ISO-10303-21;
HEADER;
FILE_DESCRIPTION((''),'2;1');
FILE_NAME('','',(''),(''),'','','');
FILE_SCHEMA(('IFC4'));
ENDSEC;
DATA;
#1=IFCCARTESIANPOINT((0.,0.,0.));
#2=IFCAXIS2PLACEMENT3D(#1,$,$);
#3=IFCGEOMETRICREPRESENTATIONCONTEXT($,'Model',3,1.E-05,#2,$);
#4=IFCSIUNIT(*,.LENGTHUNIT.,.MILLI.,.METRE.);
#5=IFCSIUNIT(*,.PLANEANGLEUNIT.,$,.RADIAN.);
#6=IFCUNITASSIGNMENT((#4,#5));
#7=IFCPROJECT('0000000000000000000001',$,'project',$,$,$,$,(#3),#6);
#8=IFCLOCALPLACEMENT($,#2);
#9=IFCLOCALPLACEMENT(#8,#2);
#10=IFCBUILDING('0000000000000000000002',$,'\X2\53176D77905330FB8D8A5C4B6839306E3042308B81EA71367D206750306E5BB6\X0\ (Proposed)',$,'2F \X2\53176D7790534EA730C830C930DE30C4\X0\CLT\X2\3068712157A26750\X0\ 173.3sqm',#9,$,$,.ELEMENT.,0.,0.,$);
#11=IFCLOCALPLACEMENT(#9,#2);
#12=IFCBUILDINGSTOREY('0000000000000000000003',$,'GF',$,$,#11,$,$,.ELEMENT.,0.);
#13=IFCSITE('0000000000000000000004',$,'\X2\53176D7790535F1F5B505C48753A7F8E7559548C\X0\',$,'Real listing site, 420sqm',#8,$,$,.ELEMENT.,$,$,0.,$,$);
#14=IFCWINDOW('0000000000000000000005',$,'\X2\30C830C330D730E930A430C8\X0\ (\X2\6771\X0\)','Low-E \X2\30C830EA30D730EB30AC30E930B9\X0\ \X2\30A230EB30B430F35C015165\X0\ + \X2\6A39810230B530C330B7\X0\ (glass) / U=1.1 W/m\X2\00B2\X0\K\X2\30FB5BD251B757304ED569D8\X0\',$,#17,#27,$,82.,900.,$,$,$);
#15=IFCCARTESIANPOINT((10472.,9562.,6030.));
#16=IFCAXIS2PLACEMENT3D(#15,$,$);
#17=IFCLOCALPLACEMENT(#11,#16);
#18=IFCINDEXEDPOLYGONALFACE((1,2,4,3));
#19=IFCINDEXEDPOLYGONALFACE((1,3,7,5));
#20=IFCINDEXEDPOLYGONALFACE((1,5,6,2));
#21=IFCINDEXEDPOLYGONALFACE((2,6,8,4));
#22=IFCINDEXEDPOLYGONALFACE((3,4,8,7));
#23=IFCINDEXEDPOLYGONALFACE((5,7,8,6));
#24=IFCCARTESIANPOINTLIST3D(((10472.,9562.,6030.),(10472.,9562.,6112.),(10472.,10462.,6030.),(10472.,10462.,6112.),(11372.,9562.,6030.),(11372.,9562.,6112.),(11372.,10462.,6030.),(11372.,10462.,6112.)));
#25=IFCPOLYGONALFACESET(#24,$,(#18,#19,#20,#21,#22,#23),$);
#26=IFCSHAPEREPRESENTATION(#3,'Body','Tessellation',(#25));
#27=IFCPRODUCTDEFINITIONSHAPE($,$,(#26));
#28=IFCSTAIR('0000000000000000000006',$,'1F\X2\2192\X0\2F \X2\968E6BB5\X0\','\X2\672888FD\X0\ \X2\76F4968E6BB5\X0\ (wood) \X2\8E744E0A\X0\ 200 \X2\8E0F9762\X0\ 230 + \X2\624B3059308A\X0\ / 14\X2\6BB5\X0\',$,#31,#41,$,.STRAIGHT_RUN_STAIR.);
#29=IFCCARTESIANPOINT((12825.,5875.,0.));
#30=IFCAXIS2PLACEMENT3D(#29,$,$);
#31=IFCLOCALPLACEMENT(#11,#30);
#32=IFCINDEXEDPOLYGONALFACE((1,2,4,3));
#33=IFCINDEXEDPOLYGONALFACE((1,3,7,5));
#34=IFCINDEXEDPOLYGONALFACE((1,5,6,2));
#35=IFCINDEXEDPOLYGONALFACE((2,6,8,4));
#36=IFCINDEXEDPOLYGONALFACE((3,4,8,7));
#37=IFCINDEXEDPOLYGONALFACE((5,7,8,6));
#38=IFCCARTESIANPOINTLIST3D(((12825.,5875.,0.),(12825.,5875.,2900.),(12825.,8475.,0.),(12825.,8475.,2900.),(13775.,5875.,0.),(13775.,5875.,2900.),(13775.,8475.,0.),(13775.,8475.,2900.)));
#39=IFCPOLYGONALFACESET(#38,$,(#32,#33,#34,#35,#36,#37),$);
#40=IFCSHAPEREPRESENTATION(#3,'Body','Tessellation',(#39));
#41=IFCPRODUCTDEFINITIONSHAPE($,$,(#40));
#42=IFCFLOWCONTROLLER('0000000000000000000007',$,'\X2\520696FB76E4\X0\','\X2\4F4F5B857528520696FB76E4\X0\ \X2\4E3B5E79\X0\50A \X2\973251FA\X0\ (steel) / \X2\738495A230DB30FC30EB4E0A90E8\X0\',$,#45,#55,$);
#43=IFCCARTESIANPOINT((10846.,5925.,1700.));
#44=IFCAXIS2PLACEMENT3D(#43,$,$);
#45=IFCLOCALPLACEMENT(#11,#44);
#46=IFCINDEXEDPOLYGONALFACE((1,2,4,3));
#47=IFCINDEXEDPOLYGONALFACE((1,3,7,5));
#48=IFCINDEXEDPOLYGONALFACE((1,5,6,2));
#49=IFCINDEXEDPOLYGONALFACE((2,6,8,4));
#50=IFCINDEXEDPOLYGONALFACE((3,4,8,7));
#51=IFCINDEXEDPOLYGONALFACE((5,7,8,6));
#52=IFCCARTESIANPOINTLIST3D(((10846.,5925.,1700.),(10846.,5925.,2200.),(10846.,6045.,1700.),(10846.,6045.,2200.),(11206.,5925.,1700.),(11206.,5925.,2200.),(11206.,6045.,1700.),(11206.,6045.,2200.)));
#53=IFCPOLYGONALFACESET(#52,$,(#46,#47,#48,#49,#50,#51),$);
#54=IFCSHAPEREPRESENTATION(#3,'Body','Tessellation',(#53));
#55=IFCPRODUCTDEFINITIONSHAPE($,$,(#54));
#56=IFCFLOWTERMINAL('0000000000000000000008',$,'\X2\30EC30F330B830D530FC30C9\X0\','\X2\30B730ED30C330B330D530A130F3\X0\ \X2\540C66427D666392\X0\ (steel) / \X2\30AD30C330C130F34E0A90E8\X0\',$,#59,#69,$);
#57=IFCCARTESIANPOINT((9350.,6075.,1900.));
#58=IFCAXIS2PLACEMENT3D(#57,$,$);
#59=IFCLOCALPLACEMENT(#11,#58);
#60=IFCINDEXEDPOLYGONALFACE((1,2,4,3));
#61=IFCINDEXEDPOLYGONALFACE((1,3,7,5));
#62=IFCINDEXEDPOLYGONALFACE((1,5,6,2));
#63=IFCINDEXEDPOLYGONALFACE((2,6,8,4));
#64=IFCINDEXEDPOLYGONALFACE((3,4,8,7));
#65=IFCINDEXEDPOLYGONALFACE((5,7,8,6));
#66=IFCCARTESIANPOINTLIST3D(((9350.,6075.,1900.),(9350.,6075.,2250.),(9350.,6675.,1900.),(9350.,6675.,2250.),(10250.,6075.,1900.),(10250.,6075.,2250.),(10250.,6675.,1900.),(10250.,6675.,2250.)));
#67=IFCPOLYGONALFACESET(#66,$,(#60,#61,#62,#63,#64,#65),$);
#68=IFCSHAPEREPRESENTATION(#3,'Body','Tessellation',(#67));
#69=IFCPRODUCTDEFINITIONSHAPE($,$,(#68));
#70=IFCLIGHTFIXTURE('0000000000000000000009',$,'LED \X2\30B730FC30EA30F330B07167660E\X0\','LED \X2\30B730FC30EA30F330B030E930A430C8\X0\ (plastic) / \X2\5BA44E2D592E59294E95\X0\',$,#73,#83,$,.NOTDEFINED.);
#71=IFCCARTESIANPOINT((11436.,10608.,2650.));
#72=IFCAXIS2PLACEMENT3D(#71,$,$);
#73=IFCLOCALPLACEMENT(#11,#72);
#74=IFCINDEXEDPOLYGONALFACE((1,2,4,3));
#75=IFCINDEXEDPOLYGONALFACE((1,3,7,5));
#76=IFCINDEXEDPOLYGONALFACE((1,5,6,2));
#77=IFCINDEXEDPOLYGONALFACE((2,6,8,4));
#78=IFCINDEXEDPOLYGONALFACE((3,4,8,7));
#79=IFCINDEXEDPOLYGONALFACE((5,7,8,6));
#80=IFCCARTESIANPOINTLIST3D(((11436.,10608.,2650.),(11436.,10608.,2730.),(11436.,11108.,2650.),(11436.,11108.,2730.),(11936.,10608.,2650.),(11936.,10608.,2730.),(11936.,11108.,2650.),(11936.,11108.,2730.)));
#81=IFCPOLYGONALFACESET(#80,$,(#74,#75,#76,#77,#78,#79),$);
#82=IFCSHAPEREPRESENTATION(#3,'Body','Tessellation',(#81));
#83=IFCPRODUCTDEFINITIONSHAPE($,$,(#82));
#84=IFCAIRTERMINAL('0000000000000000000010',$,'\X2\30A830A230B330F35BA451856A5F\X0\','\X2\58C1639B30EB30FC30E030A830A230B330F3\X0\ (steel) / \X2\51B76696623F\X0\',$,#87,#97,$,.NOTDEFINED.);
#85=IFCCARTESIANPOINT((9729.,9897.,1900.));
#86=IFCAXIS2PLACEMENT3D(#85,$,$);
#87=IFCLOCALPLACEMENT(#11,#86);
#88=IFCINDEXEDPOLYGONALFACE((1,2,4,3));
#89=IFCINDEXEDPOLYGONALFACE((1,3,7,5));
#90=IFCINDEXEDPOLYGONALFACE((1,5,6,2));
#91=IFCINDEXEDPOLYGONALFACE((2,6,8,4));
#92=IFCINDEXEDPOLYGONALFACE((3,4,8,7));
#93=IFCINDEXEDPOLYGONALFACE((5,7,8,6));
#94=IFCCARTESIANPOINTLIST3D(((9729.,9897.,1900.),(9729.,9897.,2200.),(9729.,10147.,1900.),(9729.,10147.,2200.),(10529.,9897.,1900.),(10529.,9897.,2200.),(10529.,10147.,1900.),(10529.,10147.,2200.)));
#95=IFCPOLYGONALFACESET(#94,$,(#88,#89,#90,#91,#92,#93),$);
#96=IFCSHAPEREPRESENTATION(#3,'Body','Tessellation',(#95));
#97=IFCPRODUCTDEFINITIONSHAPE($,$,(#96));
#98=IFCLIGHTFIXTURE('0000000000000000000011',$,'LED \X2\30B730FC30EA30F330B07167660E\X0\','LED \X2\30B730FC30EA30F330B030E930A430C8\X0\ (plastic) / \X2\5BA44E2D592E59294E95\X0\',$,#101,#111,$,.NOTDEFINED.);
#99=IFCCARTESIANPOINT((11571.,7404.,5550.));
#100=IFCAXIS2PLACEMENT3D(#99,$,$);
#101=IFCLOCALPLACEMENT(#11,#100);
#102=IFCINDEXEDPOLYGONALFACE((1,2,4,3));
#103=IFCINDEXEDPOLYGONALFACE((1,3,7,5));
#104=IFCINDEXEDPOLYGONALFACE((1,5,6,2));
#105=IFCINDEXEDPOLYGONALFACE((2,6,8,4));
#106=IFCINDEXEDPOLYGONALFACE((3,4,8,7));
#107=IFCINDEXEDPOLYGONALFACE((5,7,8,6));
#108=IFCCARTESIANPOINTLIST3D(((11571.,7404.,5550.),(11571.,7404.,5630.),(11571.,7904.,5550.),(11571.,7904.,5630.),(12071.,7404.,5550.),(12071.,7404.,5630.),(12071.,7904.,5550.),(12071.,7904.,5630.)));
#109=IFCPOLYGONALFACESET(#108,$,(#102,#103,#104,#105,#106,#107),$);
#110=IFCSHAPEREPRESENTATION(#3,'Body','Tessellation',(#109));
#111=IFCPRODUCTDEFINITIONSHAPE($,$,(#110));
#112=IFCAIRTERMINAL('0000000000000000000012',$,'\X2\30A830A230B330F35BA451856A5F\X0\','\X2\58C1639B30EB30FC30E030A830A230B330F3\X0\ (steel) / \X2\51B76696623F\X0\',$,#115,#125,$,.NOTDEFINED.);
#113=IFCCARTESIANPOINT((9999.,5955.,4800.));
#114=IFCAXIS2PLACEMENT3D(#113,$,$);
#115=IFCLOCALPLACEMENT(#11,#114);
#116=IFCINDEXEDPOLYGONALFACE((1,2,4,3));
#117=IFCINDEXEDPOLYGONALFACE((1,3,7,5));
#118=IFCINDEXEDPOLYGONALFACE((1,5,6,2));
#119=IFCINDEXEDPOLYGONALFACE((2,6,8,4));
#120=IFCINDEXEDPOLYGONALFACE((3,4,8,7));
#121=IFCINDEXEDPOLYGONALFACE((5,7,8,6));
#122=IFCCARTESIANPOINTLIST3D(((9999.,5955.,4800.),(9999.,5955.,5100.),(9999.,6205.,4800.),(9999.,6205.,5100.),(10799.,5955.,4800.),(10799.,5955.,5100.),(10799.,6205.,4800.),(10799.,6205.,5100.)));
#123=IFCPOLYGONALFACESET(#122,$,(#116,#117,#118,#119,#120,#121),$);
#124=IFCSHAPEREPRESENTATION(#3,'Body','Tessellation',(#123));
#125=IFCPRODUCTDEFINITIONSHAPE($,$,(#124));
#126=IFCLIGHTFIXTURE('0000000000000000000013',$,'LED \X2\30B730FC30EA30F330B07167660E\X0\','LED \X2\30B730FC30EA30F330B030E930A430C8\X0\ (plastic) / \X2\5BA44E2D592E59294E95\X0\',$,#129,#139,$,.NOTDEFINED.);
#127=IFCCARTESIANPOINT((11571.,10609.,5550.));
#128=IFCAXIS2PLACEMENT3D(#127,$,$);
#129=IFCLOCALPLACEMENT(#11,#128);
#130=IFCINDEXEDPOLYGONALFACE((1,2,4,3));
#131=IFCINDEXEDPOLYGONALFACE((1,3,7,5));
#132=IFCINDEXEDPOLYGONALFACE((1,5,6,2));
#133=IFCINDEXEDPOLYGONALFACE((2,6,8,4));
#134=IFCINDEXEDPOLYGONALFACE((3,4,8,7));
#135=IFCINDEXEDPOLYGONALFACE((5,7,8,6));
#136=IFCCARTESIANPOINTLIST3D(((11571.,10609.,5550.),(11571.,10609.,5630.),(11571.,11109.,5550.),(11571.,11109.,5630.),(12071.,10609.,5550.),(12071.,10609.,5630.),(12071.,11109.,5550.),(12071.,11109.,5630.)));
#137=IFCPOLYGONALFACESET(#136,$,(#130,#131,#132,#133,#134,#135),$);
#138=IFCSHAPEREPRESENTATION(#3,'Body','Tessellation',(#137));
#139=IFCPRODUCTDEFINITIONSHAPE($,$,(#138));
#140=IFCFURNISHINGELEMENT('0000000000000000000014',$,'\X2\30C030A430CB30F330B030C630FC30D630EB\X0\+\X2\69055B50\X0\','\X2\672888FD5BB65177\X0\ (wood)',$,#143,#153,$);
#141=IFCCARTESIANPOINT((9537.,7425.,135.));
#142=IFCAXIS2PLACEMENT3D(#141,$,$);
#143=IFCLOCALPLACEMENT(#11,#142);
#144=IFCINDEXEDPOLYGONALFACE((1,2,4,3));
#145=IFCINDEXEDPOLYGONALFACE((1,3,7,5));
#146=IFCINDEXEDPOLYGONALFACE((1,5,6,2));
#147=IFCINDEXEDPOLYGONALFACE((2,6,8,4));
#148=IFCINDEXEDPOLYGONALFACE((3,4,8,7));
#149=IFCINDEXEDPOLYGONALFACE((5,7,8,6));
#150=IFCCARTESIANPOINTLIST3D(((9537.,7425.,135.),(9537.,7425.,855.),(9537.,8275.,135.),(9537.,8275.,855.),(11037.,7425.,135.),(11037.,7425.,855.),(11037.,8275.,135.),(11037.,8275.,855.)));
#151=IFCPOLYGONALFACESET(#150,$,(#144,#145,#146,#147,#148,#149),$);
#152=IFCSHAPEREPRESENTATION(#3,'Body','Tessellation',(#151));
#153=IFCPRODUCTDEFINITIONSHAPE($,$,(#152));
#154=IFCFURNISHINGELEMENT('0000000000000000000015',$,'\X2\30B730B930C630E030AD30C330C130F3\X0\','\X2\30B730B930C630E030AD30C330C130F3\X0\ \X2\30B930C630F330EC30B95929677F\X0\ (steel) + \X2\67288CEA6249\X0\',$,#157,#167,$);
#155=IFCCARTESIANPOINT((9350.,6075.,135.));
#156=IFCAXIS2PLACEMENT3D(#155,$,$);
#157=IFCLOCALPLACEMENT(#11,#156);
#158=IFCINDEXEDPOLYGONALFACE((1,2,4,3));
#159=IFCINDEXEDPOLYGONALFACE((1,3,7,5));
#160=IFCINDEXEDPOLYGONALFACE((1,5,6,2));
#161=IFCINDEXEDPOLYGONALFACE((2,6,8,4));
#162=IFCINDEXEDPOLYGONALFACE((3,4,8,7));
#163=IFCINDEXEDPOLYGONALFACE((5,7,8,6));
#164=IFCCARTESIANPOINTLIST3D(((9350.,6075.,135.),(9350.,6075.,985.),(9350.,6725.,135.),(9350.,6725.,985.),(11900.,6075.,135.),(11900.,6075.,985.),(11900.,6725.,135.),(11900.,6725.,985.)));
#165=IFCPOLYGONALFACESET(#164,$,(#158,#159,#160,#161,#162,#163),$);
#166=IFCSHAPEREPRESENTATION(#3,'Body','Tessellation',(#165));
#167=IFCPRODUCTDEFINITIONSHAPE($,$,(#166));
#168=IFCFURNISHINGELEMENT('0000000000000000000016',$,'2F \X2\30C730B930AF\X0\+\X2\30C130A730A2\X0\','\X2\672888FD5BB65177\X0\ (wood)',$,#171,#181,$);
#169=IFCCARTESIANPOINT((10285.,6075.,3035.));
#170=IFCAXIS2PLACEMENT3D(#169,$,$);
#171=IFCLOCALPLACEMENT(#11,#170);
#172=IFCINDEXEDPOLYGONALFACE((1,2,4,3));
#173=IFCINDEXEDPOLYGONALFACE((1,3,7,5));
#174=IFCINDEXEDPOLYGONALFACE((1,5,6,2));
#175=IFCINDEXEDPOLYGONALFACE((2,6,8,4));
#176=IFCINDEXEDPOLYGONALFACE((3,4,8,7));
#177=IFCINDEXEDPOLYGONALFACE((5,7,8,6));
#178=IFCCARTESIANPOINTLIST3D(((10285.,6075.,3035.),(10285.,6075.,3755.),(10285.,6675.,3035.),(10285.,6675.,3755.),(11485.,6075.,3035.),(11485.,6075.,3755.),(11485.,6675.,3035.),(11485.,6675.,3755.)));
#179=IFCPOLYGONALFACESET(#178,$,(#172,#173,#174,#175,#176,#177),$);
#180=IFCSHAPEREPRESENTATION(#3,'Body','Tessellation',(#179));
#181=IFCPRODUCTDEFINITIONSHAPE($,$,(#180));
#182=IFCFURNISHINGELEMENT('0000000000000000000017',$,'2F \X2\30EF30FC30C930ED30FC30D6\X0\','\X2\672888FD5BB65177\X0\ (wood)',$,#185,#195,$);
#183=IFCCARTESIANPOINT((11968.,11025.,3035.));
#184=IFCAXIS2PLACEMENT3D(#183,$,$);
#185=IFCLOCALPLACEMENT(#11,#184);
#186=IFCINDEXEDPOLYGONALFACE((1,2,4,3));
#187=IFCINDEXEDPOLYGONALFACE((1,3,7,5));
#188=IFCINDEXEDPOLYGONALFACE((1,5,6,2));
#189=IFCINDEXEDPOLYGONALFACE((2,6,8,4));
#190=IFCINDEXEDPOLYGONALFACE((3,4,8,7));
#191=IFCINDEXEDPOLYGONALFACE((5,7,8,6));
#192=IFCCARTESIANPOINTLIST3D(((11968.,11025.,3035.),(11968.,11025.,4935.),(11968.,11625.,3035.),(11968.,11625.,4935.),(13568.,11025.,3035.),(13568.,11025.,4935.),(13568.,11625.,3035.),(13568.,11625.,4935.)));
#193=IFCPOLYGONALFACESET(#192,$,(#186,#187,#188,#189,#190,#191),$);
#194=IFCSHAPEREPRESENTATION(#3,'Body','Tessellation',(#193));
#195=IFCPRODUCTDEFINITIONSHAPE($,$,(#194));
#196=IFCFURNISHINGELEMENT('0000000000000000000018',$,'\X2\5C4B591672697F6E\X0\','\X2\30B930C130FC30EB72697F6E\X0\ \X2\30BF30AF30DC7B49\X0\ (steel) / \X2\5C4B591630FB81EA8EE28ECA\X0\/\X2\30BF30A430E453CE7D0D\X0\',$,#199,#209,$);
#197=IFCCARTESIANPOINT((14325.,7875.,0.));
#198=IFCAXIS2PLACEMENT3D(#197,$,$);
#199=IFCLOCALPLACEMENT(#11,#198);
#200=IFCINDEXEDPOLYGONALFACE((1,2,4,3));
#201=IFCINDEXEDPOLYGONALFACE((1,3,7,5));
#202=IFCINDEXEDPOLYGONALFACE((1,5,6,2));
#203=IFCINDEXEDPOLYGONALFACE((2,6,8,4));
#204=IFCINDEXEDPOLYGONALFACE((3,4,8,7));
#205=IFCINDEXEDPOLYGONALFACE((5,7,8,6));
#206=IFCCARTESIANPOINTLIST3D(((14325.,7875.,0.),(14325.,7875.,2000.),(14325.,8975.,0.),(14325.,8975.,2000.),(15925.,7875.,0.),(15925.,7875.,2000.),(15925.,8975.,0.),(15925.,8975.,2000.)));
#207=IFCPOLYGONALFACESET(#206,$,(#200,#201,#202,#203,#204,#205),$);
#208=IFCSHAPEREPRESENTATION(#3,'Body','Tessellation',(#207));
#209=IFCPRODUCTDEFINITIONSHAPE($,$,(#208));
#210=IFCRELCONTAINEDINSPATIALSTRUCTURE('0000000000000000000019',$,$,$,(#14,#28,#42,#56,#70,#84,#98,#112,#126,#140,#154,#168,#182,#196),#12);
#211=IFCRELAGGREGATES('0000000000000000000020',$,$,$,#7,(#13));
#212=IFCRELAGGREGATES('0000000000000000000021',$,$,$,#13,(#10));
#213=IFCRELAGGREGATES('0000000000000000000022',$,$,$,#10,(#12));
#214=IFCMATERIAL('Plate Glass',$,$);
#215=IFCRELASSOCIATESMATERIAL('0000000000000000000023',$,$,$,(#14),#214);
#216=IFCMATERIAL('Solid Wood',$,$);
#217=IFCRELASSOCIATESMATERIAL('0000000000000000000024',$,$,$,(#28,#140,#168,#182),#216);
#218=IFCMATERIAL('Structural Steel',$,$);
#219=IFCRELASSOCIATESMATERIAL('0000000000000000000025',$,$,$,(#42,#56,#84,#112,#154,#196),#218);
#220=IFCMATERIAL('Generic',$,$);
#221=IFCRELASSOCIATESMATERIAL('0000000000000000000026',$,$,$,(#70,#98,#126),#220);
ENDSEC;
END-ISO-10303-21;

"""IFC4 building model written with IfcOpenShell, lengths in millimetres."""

from ifc_helpers import new_model, si_unit, frame, frame_2d, origin, place, context, project, spatial, rectangle, extrude, material, element, save


model = new_model("IFC4")

# Units and contexts
model_context = context("Model", 3, precision=1e-05, world=origin())
ifc_project = project(units=[si_unit("LENGTHUNIT", "METRE", prefix="MILLI"), si_unit("PLANEANGLEUNIT", "RADIAN")], contexts=[model_context])

# Site, building, storey
site_placement = place(None, origin())
site = spatial("IfcSite", under=ifc_project, at=site_placement, Name="北海道弟子屈町美留和", ObjectType="Real listing site, 420sqm", CompositionType="ELEMENT", RefElevation=0.0)
building_placement = place(site_placement, origin())
building = spatial("IfcBuilding", under=site, at=building_placement, Name="北海道・越屋根のある自然素材の家 (Proposed)", ObjectType="2F 北海道产トドマツCLTと無垢材 173.3sqm", CompositionType="ELEMENT", ElevationOfRefHeight=0.0, ElevationOfTerrain=0.0)
storey_placement = place(building_placement, origin())
storey = spatial("IfcBuildingStorey", under=building, at=storey_placement, Name="GF", CompositionType="ELEMENT", Elevation=0.0)

# Shared definitions
ifc_material_1 = material(Name="Solid Wood")

# Window
ifc_material_2 = material(Name="Plate Glass")
window_placement = place(storey_placement, frame((10472.0, 9562.0, 6030.0)))
element("IfcWindow", 1, at=window_placement, inside=storey, material=ifc_material_2, Name="トップライト (東)", Description="Low-E トリプルガラス アルゴン封入 + 樹脂サッシ (glass) / U=1.1 W/m²K・寒冷地仕様", OverallHeight=82.0, OverallWidth=900.0, context=model_context, shape_type="SweptSolid", body=[
    extrude(rectangle(XDim=900.0, YDim=900.0, at=frame_2d((450.0, 450.0))), frame((10472.0, 9562.0, 6030.0)), (0.0, 0.0, 1.0), 82.0),
])

# Stair
stair_placement = place(storey_placement, frame((12825.0, 5875.0, 0.0)))
element("IfcStair", 2, at=stair_placement, inside=storey, material=ifc_material_1, Name="1F→2F 階段", Description="木製 直階段 (wood) 蹴上 200 踏面 230 + 手すり / 14段", PredefinedType="STRAIGHT_RUN_STAIR", context=model_context, shape_type="SweptSolid", body=[
    extrude(rectangle(XDim=950.0, YDim=2600.0, at=frame_2d((475.0, 1300.0))), frame((12825.0, 5875.0, 0.0)), (0.0, 0.0, 1.0), 2900.0),
])

# Flow controller
ifc_material_3 = material(Name="Structural Steel")
flow_controller_placement = place(storey_placement, frame((10846.0, 5925.0, 1700.0)))
element("IfcFlowController", 3, at=flow_controller_placement, inside=storey, material=ifc_material_3, Name="分電盤", Description="住宅用分電盤 主幹50A 露出 (steel) / 玄関ホール上部", context=model_context, shape_type="SweptSolid", body=[
    extrude(rectangle(XDim=360.0, YDim=120.0, at=frame_2d((180.0, 60.0))), frame((10846.0, 5925.0, 1700.0)), (0.0, 0.0, 1.0), 500.0),
])

# Flow terminal
flow_terminal_placement = place(storey_placement, frame((9350.0, 6075.0, 1900.0)))
element("IfcFlowTerminal", 4, at=flow_terminal_placement, inside=storey, material=ifc_material_3, Name="レンジフード", Description="シロッコファン 同時給排 (steel) / キッチン上部", context=model_context, shape_type="SweptSolid", body=[
    extrude(rectangle(XDim=900.0, YDim=600.0, at=frame_2d((450.0, 300.0))), frame((9350.0, 6075.0, 1900.0)), (0.0, 0.0, 1.0), 350.0),
])

# Light fixture
ifc_material_4 = material(Name="Generic")
light_fixture_1_placement = place(storey_placement, frame((11436.0, 10608.0, 2650.0)))
element("IfcLightFixture", 5, at=light_fixture_1_placement, inside=storey, material=ifc_material_4, Name="LED シーリング照明", Description="LED シーリングライト (plastic) / 室中央天井", PredefinedType="NOTDEFINED", context=model_context, shape_type="SweptSolid", body=[
    extrude(rectangle(XDim=500.0, YDim=500.0, at=frame_2d((250.0, 250.0))), frame((11436.0, 10608.0, 2650.0)), (0.0, 0.0, 1.0), 80.0),
])

# Air terminal
air_terminal_1_placement = place(storey_placement, frame((9729.0, 9897.0, 1900.0)))
element("IfcAirTerminal", 6, at=air_terminal_1_placement, inside=storey, material=ifc_material_3, Name="エアコン室内機", Description="壁掛ルームエアコン (steel) / 冷暖房", PredefinedType="NOTDEFINED", context=model_context, shape_type="SweptSolid", body=[
    extrude(rectangle(XDim=800.0, YDim=250.0, at=frame_2d((400.0, 125.0))), frame((9729.0, 9897.0, 1900.0)), (0.0, 0.0, 1.0), 300.0),
])

# Light fixture
light_fixture_2_placement = place(storey_placement, frame((11571.0, 7404.0, 5550.0)))
element("IfcLightFixture", 7, at=light_fixture_2_placement, inside=storey, material=ifc_material_4, Name="LED シーリング照明", Description="LED シーリングライト (plastic) / 室中央天井", PredefinedType="NOTDEFINED", context=model_context, shape_type="SweptSolid", body=[
    extrude(rectangle(XDim=500.0, YDim=500.0, at=frame_2d((250.0, 250.0))), frame((11571.0, 7404.0, 5550.0)), (0.0, 0.0, 1.0), 80.0),
])

# Air terminal
air_terminal_2_placement = place(storey_placement, frame((9999.0, 5955.0, 4800.0)))
element("IfcAirTerminal", 8, at=air_terminal_2_placement, inside=storey, material=ifc_material_3, Name="エアコン室内機", Description="壁掛ルームエアコン (steel) / 冷暖房", PredefinedType="NOTDEFINED", context=model_context, shape_type="SweptSolid", body=[
    extrude(rectangle(XDim=800.0, YDim=250.0, at=frame_2d((400.0, 125.0))), frame((9999.0, 5955.0, 4800.0)), (0.0, 0.0, 1.0), 300.0),
])

# Light fixture
light_fixture_3_placement = place(storey_placement, frame((11571.0, 10609.0, 5550.0)))
element("IfcLightFixture", 9, at=light_fixture_3_placement, inside=storey, material=ifc_material_4, Name="LED シーリング照明", Description="LED シーリングライト (plastic) / 室中央天井", PredefinedType="NOTDEFINED", context=model_context, shape_type="SweptSolid", body=[
    extrude(rectangle(XDim=500.0, YDim=500.0, at=frame_2d((250.0, 250.0))), frame((11571.0, 10609.0, 5550.0)), (0.0, 0.0, 1.0), 80.0),
])

# Furnishing elements
furnishing_1_placement = place(storey_placement, frame((9537.0, 7425.0, 135.0)))
element("IfcFurnishingElement", 10, at=furnishing_1_placement, inside=storey, material=ifc_material_1, Name="ダイニングテーブル+椅子", Description="木製家具 (wood)", context=model_context, shape_type="SweptSolid", body=[
    extrude(rectangle(XDim=1500.0, YDim=850.0, at=frame_2d((750.0, 425.0))), frame((9537.0, 7425.0, 135.0)), (0.0, 0.0, 1.0), 720.0),
])
furnishing_2_placement = place(storey_placement, frame((9350.0, 6075.0, 135.0)))
element("IfcFurnishingElement", 11, at=furnishing_2_placement, inside=storey, material=ifc_material_3, Name="システムキッチン", Description="システムキッチン ステンレス天板 (steel) + 木質扉", context=model_context, shape_type="SweptSolid", body=[
    extrude(rectangle(XDim=2550.0, YDim=650.0, at=frame_2d((1275.0, 325.0))), frame((9350.0, 6075.0, 135.0)), (0.0, 0.0, 1.0), 850.0),
])
furnishing_3_placement = place(storey_placement, frame((10285.0, 6075.0, 3035.0)))
element("IfcFurnishingElement", 12, at=furnishing_3_placement, inside=storey, material=ifc_material_1, Name="2F デスク+チェア", Description="木製家具 (wood)", context=model_context, shape_type="SweptSolid", body=[
    extrude(rectangle(XDim=1200.0, YDim=600.0, at=frame_2d((600.0, 300.0))), frame((10285.0, 6075.0, 3035.0)), (0.0, 0.0, 1.0), 720.0),
])
furnishing_4_placement = place(storey_placement, frame((11968.0, 11025.0, 3035.0)))
element("IfcFurnishingElement", 13, at=furnishing_4_placement, inside=storey, material=ifc_material_1, Name="2F ワードローブ", Description="木製家具 (wood)", context=model_context, shape_type="SweptSolid", body=[
    extrude(rectangle(XDim=1600.0, YDim=600.0, at=frame_2d((800.0, 300.0))), frame((11968.0, 11025.0, 3035.0)), (0.0, 0.0, 1.0), 1900.0),
])
furnishing_5_placement = place(storey_placement, frame((14325.0, 7875.0, 0.0)))
element("IfcFurnishingElement", 14, at=furnishing_5_placement, inside=storey, material=ifc_material_3, Name="屋外物置", Description="スチール物置 タクボ等 (steel) / 屋外・自転車/タイヤ収納", context=model_context, shape_type="SweptSolid", body=[
    extrude(rectangle(XDim=1600.0, YDim=1100.0, at=frame_2d((800.0, 550.0))), frame((14325.0, 7875.0, 0.0)), (0.0, 0.0, 1.0), 2000.0),
])

save(model, "model.ifc")
